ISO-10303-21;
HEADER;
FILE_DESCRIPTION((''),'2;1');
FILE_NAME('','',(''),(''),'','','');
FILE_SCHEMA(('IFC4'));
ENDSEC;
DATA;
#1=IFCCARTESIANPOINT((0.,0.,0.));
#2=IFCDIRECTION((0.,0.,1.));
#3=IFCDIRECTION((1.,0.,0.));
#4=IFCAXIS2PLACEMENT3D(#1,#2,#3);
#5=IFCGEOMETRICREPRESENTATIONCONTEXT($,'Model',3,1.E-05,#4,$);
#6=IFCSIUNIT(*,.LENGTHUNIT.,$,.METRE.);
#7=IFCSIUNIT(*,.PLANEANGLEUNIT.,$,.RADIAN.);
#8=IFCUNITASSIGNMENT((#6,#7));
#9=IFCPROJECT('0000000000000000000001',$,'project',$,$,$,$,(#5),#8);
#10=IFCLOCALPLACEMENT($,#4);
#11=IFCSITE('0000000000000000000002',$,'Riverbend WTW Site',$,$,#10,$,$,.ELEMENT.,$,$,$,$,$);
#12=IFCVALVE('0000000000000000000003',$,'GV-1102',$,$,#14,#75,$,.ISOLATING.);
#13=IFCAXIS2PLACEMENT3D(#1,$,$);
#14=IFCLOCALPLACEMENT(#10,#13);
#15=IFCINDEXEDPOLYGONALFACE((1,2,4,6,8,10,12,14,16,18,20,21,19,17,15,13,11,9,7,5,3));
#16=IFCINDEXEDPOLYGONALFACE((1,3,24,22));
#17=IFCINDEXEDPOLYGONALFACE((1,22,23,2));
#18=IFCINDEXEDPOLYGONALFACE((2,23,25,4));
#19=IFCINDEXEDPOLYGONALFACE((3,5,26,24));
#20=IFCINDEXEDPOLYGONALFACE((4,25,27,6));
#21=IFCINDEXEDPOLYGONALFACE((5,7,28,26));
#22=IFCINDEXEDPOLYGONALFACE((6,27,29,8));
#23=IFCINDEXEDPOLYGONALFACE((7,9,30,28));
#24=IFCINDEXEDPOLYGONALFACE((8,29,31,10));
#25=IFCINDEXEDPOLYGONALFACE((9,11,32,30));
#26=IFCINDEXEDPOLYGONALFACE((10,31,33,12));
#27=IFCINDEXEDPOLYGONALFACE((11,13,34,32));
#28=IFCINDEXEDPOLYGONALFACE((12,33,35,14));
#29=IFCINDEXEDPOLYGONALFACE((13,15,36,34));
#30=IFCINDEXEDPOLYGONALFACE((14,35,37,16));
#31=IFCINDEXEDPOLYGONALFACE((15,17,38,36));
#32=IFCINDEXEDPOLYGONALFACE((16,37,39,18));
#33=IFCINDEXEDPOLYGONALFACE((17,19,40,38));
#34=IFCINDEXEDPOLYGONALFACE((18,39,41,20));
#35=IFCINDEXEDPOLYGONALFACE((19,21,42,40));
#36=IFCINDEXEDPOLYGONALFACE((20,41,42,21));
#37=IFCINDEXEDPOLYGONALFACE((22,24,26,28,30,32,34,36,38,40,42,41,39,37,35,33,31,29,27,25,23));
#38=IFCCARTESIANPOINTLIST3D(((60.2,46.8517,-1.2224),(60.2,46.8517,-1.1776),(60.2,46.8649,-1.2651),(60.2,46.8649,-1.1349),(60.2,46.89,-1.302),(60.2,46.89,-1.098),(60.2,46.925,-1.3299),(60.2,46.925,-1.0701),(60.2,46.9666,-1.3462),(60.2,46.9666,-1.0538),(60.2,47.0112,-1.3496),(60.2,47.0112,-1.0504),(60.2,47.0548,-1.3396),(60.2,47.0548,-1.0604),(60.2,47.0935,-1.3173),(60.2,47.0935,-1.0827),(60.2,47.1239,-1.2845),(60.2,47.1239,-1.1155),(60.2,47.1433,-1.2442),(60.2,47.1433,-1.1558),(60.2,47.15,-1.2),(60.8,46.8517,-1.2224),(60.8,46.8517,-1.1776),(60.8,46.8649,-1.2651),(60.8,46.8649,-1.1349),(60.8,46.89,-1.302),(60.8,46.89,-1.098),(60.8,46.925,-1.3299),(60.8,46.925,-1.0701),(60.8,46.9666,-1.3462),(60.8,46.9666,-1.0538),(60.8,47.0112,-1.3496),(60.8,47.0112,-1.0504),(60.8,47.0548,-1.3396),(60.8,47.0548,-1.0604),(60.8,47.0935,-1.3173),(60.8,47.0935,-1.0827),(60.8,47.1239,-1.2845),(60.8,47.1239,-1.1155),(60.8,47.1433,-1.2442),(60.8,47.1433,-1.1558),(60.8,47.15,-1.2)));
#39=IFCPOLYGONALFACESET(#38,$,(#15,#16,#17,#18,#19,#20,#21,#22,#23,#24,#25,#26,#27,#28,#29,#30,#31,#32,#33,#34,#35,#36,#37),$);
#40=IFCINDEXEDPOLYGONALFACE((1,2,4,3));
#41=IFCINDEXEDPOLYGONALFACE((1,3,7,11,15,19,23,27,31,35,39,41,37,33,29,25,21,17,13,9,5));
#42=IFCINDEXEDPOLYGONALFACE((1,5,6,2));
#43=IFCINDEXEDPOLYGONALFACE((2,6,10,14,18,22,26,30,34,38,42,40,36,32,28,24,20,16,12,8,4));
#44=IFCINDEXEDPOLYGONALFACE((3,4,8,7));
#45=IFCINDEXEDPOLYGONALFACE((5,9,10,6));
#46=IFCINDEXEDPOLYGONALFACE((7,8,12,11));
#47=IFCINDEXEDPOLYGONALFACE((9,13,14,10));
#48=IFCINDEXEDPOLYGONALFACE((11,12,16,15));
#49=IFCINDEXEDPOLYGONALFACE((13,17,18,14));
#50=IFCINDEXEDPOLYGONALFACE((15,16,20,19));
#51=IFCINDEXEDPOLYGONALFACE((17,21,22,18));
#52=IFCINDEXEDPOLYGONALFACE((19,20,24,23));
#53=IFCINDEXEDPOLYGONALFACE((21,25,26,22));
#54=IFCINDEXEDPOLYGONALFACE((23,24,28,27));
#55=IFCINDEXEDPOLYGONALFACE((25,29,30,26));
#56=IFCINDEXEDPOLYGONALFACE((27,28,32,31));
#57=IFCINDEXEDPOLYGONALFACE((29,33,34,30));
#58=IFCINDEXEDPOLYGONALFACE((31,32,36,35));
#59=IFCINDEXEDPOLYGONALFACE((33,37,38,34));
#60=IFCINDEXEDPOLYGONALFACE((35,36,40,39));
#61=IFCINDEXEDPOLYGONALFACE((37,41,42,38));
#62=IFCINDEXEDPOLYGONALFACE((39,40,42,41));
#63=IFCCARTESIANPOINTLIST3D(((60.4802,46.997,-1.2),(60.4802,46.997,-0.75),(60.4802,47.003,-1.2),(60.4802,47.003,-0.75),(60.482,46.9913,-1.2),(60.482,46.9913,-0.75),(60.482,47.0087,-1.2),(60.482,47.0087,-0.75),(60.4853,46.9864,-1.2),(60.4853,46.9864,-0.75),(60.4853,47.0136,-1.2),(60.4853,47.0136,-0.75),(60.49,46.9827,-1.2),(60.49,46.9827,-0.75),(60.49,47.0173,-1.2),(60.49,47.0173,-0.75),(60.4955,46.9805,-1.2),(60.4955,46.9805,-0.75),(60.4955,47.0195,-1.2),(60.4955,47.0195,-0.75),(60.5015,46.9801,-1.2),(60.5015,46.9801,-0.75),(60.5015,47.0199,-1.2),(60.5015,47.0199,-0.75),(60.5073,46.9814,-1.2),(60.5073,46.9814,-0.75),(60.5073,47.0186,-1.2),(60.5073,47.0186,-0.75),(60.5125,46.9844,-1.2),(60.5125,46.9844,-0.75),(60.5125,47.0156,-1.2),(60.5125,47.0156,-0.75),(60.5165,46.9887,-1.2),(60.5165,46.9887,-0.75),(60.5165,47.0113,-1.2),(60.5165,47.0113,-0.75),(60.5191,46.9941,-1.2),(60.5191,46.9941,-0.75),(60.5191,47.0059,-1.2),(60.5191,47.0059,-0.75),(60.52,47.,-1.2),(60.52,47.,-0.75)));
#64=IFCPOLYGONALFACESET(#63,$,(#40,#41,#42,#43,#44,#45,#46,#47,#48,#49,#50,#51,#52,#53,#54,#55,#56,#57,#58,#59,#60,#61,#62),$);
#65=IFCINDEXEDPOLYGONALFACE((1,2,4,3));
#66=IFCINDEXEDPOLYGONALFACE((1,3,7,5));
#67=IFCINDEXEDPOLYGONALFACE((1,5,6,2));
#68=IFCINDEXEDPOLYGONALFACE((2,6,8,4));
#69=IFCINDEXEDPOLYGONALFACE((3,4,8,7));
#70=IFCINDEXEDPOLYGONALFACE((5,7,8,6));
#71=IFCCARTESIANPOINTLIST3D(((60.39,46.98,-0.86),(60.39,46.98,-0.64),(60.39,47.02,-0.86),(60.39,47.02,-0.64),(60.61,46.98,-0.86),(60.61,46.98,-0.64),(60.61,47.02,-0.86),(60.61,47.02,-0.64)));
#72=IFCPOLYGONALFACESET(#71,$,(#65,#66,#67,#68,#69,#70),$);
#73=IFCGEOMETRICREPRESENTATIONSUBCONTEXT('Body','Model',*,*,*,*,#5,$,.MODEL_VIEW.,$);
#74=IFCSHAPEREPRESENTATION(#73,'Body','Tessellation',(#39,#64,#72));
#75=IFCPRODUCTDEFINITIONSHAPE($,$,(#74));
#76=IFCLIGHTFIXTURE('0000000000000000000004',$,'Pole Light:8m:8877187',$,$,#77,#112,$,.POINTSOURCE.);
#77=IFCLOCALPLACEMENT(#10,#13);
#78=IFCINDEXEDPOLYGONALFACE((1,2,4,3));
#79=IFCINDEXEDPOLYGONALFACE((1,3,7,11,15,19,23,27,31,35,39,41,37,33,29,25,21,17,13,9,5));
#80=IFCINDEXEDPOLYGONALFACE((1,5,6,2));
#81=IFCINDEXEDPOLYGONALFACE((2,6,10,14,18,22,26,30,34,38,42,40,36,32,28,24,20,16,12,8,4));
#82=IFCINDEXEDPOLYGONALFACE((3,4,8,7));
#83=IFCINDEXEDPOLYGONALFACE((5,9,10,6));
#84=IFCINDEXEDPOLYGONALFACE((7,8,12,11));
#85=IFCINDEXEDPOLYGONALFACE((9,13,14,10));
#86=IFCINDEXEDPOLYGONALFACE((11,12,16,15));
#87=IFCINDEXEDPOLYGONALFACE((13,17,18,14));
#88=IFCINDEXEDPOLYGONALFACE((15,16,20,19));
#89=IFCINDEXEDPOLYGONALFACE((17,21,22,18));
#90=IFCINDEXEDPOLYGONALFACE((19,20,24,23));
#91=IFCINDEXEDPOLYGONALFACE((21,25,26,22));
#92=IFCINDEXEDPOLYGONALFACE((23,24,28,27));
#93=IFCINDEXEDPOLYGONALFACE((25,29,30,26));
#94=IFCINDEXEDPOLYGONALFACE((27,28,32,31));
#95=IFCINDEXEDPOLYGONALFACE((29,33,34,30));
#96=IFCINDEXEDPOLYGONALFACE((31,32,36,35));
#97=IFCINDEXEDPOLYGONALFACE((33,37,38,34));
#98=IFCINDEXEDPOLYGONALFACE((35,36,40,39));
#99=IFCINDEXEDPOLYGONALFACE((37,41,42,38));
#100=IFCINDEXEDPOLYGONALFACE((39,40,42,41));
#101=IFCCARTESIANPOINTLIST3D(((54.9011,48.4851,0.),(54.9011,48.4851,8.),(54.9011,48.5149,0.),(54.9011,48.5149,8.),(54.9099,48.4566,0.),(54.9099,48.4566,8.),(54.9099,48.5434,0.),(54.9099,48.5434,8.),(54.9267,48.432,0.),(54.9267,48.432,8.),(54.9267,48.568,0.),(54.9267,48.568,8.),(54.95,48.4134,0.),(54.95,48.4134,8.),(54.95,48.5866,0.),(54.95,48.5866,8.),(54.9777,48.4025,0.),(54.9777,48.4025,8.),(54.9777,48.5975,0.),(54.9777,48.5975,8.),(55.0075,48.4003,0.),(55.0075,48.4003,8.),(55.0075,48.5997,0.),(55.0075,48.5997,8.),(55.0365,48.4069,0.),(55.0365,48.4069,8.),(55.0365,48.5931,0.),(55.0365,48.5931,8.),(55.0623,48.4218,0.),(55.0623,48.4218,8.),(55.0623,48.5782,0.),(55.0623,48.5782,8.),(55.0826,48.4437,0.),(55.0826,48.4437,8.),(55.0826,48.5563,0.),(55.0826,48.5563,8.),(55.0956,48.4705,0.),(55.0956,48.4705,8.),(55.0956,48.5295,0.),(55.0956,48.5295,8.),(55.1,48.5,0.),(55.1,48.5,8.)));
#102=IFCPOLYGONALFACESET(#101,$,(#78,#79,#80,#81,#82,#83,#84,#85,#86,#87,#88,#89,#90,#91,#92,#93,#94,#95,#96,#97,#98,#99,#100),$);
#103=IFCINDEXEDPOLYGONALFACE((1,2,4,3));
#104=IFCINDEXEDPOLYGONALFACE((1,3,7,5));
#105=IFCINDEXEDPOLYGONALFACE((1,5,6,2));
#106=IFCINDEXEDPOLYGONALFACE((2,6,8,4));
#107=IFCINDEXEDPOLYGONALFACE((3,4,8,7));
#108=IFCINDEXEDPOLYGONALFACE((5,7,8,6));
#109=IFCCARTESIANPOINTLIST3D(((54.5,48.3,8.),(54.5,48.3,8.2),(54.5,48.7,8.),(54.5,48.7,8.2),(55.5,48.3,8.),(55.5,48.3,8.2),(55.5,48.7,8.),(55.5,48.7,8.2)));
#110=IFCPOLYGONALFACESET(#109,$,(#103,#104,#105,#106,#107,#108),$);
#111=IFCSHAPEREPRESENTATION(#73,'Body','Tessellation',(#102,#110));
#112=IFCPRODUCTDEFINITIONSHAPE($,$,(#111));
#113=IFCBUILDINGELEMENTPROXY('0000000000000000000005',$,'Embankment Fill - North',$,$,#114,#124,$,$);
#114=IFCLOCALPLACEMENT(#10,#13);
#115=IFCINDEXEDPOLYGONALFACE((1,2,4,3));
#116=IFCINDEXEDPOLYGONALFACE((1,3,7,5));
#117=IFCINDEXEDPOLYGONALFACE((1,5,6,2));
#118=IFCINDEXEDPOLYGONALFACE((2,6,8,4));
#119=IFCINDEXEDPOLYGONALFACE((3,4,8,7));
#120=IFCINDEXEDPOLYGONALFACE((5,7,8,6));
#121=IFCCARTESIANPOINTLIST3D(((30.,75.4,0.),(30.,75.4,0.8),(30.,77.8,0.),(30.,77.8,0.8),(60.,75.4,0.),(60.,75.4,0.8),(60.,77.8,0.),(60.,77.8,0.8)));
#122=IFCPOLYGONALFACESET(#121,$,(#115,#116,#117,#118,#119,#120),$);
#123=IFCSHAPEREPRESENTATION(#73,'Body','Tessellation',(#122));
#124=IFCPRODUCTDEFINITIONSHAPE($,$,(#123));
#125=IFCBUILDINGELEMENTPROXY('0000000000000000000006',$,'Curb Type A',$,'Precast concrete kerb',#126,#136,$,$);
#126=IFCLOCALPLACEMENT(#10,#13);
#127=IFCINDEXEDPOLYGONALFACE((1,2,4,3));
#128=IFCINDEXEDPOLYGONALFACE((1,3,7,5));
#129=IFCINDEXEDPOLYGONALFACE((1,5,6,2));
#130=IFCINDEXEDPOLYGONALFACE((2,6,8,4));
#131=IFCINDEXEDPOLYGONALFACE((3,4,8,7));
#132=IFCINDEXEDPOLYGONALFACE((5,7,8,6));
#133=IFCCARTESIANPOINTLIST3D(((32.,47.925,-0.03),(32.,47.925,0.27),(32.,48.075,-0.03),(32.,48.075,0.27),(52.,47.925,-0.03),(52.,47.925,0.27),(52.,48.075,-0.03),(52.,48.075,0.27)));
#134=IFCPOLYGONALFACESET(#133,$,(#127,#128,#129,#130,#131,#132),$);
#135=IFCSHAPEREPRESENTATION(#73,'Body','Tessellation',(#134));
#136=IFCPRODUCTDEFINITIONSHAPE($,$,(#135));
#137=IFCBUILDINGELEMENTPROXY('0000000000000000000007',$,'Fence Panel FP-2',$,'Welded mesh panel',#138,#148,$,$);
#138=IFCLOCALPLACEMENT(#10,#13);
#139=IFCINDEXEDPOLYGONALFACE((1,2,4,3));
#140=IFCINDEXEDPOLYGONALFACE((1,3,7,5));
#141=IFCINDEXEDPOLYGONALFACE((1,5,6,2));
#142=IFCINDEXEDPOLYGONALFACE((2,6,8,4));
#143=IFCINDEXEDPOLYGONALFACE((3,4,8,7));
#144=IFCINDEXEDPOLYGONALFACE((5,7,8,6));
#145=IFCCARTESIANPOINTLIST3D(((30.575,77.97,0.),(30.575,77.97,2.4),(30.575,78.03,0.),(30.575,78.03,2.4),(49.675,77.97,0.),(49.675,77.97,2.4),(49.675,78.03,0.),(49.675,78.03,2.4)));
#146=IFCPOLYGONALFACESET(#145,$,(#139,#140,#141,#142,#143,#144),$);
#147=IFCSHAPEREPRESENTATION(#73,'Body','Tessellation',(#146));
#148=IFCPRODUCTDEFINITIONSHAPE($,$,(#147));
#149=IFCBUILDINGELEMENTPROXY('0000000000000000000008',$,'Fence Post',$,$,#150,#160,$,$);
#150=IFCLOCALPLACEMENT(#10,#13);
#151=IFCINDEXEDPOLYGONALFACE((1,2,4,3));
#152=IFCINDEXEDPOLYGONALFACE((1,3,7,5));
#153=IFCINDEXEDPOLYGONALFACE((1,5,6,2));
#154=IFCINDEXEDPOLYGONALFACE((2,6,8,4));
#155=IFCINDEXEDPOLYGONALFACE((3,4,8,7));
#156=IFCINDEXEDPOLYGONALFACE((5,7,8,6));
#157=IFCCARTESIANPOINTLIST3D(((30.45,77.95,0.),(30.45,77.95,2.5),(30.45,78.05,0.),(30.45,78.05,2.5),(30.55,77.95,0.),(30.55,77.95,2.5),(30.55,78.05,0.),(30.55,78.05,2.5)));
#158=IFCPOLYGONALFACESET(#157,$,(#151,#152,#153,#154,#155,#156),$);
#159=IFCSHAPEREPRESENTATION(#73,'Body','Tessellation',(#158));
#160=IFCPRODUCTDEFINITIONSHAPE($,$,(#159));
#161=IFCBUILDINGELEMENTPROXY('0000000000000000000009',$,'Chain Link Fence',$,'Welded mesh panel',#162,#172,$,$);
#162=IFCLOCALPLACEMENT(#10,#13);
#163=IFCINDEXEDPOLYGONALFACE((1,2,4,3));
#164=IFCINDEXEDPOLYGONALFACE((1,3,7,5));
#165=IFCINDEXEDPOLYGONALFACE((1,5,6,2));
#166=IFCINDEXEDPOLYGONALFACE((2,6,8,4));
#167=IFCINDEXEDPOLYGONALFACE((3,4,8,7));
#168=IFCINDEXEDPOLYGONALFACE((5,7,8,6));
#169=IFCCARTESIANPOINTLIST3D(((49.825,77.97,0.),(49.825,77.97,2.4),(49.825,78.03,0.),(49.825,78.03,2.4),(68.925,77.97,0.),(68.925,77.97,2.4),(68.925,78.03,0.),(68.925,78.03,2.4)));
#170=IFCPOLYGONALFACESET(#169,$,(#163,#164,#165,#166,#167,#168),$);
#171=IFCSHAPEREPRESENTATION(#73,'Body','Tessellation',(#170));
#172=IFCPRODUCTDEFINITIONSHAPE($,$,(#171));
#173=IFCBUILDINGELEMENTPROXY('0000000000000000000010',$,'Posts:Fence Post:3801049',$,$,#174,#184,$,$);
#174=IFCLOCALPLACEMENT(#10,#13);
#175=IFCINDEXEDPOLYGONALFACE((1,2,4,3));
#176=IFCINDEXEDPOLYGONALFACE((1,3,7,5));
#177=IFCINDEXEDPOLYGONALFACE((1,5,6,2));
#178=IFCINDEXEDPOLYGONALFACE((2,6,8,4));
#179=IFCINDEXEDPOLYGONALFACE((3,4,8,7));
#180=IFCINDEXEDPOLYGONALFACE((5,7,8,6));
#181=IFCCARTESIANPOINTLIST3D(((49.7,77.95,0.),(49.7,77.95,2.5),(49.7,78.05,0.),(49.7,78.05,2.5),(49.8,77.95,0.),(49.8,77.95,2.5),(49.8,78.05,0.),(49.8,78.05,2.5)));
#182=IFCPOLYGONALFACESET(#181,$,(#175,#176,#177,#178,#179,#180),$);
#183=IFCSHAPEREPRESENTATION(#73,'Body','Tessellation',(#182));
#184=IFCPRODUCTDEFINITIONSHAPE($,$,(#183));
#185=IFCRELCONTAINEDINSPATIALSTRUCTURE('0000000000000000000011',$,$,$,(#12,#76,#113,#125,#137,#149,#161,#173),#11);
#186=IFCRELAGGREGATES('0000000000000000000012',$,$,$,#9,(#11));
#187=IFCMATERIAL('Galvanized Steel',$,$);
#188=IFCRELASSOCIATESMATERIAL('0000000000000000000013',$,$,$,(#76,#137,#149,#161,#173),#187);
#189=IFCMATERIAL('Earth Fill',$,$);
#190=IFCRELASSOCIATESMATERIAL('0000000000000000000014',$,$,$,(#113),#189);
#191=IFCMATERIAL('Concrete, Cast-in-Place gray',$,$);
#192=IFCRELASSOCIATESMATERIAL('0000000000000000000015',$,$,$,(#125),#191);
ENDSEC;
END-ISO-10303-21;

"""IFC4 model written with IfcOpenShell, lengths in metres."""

from ifc_helpers import new_model, si_unit, frame, origin_with_axes, origin_2d, place, context, subcontext, project, spatial, rectangle, circle, extrude, material, element, save


model = new_model("IFC4")

# Units and contexts
model_context = context("Model", 3, precision=1e-05, world=origin_with_axes())
body_context = subcontext(model_context, "Body", "Model", "MODEL_VIEW")
ifc_project = project(units=[si_unit("LENGTHUNIT", "METRE"), si_unit("PLANEANGLEUNIT", "RADIAN")], contexts=[model_context])

# Site
site_placement = place(None, origin_with_axes())
site = spatial("IfcSite", under=ifc_project, at=site_placement, Name="Riverbend WTW Site", CompositionType="ELEMENT")

# Valve
valve_placement = place(None, frame((60.2, 47.0, -1.2), z_axis=(0.0, 0.0, 1.0), x_axis=(1.0, 0.0, 0.0)))
element("IfcValve", 1, at=valve_placement, inside=site, Name="GV-1102", PredefinedType="ISOLATING", context=body_context, shape_type="SweptSolid", body=[
    extrude(circle(Radius=0.15, at=origin_2d()), frame((0.0, 0.0, 0.0), z_axis=(1.0, 0.0, 0.0), x_axis=(0.0, 1.0, 0.0)), (0.0, 0.0, 1.0), 0.6),
    extrude(circle(Radius=0.02, at=origin_2d()), frame((0.3, 0.0, 0.0), z_axis=(0.0, 0.0, 1.0), x_axis=(1.0, 0.0, 0.0)), (0.0, 0.0, 1.0), 0.45),
    extrude(rectangle(XDim=0.22, YDim=0.04, at=origin_2d()), frame((0.3, 0.0, 0.34), z_axis=(0.0, 0.0, 1.0), x_axis=(1.0, 0.0, 0.0)), (0.0, 0.0, 1.0), 0.22),
])

# Light fixture
ifc_material_1 = material(Name="Galvanized Steel")
light_fixture_placement = place(None, frame((55.0, 48.5, 0.0), z_axis=(0.0, 0.0, 1.0), x_axis=(1.0, 0.0, 0.0)))
element("IfcLightFixture", 2, at=light_fixture_placement, inside=site, material=ifc_material_1, Name="Pole Light:8m:8877187", PredefinedType="POINTSOURCE", context=body_context, shape_type="SweptSolid", body=[
    extrude(circle(Radius=0.1, at=origin_2d()), origin_with_axes(), (0.0, 0.0, 1.0), 8.0),
    extrude(rectangle(XDim=1.0, YDim=0.4, at=origin_2d()), frame((0.0, 0.0, 8.0), z_axis=(0.0, 0.0, 1.0), x_axis=(1.0, 0.0, 0.0)), (0.0, 0.0, 1.0), 0.2),
])

# Building element proxies
ifc_material_2 = material(Name="Earth Fill")
proxy_1_placement = place(None, frame((45.0, 76.6, 0.4), z_axis=(0.0, 0.0, 1.0), x_axis=(1.0, 0.0, 0.0)))
element("IfcBuildingElementProxy", 3, at=proxy_1_placement, inside=site, material=ifc_material_2, Name="Embankment Fill - North", context=body_context, shape_type="SweptSolid", body=[
    extrude(rectangle(XDim=30.0, YDim=2.4, at=origin_2d()), frame((0.0, 0.0, -0.4), z_axis=(0.0, 0.0, 1.0), x_axis=(1.0, 0.0, 0.0)), (0.0, 0.0, 1.0), 0.8),
])
ifc_material_3 = material(Name="Concrete, Cast-in-Place gray")
proxy_2_placement = place(None, frame((42.0, 48.0, 0.12), z_axis=(0.0, 0.0, 1.0), x_axis=(1.0, 0.0, 0.0)))
element("IfcBuildingElementProxy", 4, at=proxy_2_placement, inside=site, material=ifc_material_3, Name="Curb Type A", ObjectType="Precast concrete kerb", context=body_context, shape_type="SweptSolid", body=[
    extrude(rectangle(XDim=20.0, YDim=0.15, at=origin_2d()), frame((0.0, 0.0, -0.15), z_axis=(0.0, 0.0, 1.0), x_axis=(1.0, 0.0, 0.0)), (0.0, 0.0, 1.0), 0.3),
])
proxy_3_placement = place(None, frame((40.125, 78.0, 1.2), z_axis=(0.0, 0.0, 1.0), x_axis=(1.0, 0.0, 0.0)))
element("IfcBuildingElementProxy", 5, at=proxy_3_placement, inside=site, material=ifc_material_1, Name="Fence Panel FP-2", ObjectType="Welded mesh panel", context=body_context, shape_type="SweptSolid", body=[
    extrude(rectangle(XDim=19.1, YDim=0.06, at=origin_2d()), frame((0.0, 0.0, -1.2), z_axis=(0.0, 0.0, 1.0), x_axis=(1.0, 0.0, 0.0)), (0.0, 0.0, 1.0), 2.4),
])
proxy_4_placement = place(None, frame((30.5, 78.0, 1.25), z_axis=(0.0, 0.0, 1.0), x_axis=(1.0, 0.0, 0.0)))
element("IfcBuildingElementProxy", 6, at=proxy_4_placement, inside=site, material=ifc_material_1, Name="Fence Post", context=body_context, shape_type="SweptSolid", body=[
    extrude(rectangle(XDim=0.1, YDim=0.1, at=origin_2d()), frame((0.0, 0.0, -1.25), z_axis=(0.0, 0.0, 1.0), x_axis=(1.0, 0.0, 0.0)), (0.0, 0.0, 1.0), 2.5),
])
proxy_5_placement = place(None, frame((59.375, 78.0, 1.2), z_axis=(0.0, 0.0, 1.0), x_axis=(1.0, 0.0, 0.0)))
element("IfcBuildingElementProxy", 7, at=proxy_5_placement, inside=site, material=ifc_material_1, Name="Chain Link Fence", ObjectType="Welded mesh panel", context=body_context, shape_type="SweptSolid", body=[
    extrude(rectangle(XDim=19.1, YDim=0.06, at=origin_2d()), frame((0.0, 0.0, -1.2), z_axis=(0.0, 0.0, 1.0), x_axis=(1.0, 0.0, 0.0)), (0.0, 0.0, 1.0), 2.4),
])
proxy_6_placement = place(None, frame((49.75, 78.0, 1.25), z_axis=(0.0, 0.0, 1.0), x_axis=(1.0, 0.0, 0.0)))
element("IfcBuildingElementProxy", 8, at=proxy_6_placement, inside=site, material=ifc_material_1, Name="Posts:Fence Post:3801049", context=body_context, shape_type="SweptSolid", body=[
    extrude(rectangle(XDim=0.1, YDim=0.1, at=origin_2d()), frame((0.0, 0.0, -1.25), z_axis=(0.0, 0.0, 1.0), x_axis=(1.0, 0.0, 0.0)), (0.0, 0.0, 1.0), 2.5),
])

save(model, "model.ifc")
